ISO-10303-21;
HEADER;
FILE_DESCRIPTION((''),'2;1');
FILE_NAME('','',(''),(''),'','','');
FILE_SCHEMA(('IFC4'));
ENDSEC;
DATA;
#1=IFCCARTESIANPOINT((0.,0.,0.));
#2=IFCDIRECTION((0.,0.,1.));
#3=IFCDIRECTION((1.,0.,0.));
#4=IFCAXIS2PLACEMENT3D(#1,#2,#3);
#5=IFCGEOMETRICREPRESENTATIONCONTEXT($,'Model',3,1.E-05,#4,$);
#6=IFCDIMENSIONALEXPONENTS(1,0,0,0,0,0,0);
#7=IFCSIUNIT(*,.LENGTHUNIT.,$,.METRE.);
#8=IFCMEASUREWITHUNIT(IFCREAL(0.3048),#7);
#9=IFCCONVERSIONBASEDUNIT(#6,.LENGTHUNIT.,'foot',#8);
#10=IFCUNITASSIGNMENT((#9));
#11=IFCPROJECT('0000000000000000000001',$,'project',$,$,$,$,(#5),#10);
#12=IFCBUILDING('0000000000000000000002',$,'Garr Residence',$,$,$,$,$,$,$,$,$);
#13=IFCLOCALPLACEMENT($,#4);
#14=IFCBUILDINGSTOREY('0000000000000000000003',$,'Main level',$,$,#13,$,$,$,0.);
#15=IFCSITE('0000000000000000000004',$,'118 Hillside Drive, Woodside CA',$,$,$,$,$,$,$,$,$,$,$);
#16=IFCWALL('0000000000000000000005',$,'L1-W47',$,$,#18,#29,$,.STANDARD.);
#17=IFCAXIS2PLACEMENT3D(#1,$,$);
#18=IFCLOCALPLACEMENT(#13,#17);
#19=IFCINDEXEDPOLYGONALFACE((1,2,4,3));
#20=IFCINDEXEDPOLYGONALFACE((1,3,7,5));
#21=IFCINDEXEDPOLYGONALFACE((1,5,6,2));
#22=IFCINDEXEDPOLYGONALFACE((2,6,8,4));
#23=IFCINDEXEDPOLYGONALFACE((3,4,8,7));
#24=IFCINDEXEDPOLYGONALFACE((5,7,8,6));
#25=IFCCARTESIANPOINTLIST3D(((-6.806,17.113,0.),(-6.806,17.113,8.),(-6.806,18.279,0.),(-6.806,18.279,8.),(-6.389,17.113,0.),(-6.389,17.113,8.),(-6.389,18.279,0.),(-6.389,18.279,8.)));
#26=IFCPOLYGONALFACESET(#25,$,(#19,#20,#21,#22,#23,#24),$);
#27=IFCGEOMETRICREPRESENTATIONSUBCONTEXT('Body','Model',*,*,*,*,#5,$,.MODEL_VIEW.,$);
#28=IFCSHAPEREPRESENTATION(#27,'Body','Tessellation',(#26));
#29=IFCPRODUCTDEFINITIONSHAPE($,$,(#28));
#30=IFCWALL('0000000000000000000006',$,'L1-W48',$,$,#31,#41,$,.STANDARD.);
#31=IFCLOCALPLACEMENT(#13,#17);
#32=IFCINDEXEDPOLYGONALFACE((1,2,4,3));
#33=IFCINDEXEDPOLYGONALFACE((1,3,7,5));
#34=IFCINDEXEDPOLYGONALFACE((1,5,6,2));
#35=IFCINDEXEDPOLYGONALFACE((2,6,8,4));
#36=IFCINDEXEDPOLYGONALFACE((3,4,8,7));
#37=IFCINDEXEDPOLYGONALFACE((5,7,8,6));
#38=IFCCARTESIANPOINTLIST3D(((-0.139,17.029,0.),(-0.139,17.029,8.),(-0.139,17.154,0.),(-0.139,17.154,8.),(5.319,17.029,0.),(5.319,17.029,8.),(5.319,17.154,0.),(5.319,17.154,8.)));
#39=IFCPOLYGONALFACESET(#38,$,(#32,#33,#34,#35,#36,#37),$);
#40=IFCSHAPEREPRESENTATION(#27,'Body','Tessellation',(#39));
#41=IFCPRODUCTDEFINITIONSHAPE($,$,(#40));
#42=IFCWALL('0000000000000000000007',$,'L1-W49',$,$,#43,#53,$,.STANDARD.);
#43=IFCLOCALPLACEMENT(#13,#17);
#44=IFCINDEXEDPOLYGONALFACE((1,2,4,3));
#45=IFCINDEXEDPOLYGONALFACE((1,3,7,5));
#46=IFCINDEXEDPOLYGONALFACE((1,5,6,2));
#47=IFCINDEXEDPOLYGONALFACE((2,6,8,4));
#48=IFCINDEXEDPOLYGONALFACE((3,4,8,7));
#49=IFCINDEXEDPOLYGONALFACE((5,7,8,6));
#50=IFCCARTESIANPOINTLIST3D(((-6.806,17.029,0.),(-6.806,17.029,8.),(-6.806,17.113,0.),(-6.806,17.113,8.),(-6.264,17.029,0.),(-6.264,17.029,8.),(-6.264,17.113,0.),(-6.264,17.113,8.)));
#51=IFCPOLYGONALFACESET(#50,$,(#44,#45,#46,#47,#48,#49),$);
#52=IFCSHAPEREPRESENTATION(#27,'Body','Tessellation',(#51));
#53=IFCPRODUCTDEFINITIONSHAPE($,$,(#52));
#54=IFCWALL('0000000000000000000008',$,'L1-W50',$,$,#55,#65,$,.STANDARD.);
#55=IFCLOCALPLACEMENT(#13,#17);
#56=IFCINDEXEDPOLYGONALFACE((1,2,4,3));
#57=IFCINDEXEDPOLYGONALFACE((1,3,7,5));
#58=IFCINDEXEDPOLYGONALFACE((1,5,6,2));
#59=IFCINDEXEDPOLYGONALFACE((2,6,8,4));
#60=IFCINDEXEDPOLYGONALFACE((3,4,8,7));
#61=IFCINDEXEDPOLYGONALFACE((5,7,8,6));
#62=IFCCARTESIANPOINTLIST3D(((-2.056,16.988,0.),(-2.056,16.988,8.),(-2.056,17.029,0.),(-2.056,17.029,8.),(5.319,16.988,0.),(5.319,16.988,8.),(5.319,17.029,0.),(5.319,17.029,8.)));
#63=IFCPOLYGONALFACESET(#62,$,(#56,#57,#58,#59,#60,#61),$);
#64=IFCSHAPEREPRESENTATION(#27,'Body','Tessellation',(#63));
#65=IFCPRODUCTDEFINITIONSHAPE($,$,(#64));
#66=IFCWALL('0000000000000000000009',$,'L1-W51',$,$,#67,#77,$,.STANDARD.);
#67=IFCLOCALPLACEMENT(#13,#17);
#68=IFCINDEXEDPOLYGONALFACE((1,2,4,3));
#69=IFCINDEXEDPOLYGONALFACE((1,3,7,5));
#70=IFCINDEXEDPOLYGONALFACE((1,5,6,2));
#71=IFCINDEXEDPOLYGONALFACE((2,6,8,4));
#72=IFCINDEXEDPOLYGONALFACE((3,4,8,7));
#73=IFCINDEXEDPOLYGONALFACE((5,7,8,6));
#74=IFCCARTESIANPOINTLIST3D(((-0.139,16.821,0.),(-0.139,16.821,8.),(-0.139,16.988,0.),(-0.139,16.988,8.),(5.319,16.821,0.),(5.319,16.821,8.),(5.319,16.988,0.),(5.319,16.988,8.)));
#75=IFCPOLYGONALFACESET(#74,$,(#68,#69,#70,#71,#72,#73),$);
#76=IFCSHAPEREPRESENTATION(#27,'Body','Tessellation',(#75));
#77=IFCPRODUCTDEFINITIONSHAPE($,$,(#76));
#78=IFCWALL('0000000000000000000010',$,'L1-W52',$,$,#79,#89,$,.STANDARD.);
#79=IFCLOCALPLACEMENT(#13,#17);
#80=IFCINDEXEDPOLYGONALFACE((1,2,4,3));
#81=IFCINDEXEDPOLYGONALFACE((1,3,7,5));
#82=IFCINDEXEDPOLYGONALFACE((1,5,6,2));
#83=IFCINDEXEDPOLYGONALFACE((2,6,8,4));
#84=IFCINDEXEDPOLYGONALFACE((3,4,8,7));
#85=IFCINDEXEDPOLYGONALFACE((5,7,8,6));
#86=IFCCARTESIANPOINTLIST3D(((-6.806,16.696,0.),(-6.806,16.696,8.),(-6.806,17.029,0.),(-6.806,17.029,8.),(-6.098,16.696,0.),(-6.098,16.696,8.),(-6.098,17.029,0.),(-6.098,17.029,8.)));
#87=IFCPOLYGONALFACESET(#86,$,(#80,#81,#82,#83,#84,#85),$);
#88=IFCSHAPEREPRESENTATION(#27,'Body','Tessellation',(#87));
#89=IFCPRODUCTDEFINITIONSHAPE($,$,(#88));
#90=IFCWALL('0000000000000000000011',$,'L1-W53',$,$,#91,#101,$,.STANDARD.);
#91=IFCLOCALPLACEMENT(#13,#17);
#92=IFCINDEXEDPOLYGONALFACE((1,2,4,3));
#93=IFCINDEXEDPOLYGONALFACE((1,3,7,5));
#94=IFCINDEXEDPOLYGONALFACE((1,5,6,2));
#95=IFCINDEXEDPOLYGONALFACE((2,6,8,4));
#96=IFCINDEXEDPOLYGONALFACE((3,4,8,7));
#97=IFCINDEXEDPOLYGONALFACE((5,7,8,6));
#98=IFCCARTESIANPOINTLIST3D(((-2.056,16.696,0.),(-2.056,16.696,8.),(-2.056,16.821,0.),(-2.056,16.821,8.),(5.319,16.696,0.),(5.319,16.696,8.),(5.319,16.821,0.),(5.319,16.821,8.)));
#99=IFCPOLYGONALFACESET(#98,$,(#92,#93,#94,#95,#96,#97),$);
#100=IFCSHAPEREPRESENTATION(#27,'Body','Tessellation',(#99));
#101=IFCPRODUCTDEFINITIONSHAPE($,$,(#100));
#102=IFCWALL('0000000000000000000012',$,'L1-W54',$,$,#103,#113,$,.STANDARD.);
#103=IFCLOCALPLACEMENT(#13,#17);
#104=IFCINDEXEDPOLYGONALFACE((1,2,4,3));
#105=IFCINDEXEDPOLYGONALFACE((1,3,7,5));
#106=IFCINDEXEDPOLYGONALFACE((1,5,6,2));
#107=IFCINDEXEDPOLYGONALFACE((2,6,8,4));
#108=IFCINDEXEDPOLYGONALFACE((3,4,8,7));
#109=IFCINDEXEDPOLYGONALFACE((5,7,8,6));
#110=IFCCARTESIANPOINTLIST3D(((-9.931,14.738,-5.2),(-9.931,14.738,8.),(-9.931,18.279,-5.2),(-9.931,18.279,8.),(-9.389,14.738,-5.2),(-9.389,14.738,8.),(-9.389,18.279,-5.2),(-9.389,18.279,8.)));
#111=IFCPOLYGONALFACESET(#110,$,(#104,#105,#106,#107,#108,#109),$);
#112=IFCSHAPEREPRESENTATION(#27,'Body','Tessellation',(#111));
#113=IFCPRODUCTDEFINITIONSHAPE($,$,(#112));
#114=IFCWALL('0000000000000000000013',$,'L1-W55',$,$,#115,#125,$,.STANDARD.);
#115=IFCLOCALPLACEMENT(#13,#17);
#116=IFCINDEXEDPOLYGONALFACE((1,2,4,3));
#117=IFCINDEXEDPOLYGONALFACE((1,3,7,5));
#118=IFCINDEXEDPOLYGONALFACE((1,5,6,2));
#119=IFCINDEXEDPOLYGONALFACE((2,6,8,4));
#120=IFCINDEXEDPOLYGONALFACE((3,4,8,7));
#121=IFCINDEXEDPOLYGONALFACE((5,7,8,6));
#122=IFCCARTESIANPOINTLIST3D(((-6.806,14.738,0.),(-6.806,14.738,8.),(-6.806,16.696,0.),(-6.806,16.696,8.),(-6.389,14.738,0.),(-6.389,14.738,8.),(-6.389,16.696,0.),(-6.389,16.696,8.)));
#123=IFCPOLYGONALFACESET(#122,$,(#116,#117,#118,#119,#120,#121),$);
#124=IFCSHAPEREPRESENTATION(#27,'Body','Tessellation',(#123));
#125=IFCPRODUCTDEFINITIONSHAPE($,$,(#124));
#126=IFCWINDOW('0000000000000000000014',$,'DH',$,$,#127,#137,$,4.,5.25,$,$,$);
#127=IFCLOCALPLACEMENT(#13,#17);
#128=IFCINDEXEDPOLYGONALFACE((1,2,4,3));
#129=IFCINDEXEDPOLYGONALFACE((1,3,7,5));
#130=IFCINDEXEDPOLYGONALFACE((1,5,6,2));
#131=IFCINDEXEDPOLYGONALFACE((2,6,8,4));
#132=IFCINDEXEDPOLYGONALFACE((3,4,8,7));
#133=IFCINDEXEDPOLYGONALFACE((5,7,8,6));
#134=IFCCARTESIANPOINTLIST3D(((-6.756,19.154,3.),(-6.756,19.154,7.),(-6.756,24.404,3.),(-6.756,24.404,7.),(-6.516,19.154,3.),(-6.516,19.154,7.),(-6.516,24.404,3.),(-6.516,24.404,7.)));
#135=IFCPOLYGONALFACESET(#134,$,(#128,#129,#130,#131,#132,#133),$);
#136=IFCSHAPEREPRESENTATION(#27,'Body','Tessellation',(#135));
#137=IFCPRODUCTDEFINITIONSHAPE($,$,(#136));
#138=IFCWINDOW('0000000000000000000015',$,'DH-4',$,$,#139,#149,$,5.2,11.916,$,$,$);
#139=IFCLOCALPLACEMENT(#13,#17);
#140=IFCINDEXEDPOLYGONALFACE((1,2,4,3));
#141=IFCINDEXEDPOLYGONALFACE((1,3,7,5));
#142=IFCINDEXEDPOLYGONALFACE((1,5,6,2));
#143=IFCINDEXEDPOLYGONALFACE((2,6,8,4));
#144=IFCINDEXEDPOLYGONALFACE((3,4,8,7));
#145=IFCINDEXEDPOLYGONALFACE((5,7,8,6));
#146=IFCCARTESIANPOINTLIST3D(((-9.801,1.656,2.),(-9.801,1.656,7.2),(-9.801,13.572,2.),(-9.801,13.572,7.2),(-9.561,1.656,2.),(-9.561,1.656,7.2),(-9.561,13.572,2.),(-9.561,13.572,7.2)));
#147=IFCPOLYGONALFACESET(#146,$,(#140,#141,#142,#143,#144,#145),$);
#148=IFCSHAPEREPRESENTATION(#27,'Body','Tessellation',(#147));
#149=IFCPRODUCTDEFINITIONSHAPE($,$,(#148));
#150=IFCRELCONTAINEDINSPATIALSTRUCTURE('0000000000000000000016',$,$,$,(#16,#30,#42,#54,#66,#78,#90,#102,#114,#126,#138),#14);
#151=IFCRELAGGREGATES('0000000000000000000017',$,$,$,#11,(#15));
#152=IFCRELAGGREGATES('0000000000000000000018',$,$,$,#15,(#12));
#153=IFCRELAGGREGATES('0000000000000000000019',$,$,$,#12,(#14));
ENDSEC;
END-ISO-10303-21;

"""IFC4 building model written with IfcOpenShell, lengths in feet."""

from ifc_helpers import new_model, entity, si_unit, converted_unit, frame, origin, origin_with_axes, place, context, subcontext, project, spatial, polyline, outline, extrude, element, save


model = new_model("IFC4")

# Units and contexts
model_context = context("Model", 3, precision=1e-05, world=origin_with_axes())
body_context = subcontext(model_context, "Body", "Model", "MODEL_VIEW")
ifc_project = project(units=[converted_unit("LENGTHUNIT", "foot", entity("IfcReal", 0.3048), si_unit("LENGTHUNIT", "METRE"), dimensions=[1, 0, 0, 0, 0, 0, 0])], contexts=[model_context])

# Site, building, storey
site = spatial("IfcSite", under=ifc_project, Name="118 Hillside Drive, Woodside CA")
building = spatial("IfcBuilding", under=site, Name="Garr Residence")
storey_placement = place(None, origin_with_axes())
storey = spatial("IfcBuildingStorey", under=building, at=storey_placement, Name="Main level", Elevation=0.0)

# Walls
wall_1_placement = place(storey_placement, origin_with_axes())
element("IfcWall", 1, at=wall_1_placement, inside=storey, Name="L1-W47", PredefinedType="STANDARD", context=body_context, shape_type="SweptSolid", body=[
    extrude(outline(polyline([(-6.389, 17.113), (-6.389, 18.279), (-6.806, 18.279), (-6.806, 17.113), (-6.389, 17.113)])), origin(), (0.0, 0.0, 1.0), 8.0),
])
wall_2_placement = place(storey_placement, origin_with_axes())
element("IfcWall", 2, at=wall_2_placement, inside=storey, Name="L1-W48", PredefinedType="STANDARD", context=body_context, shape_type="SweptSolid", body=[
    extrude(outline(polyline([(5.319, 17.029), (5.319, 17.154), (-0.139, 17.154), (-0.139, 17.029), (5.319, 17.029)])), origin(), (0.0, 0.0, 1.0), 8.0),
])
wall_3_placement = place(storey_placement, origin_with_axes())
element("IfcWall", 3, at=wall_3_placement, inside=storey, Name="L1-W49", PredefinedType="STANDARD", context=body_context, shape_type="SweptSolid", body=[
    extrude(outline(polyline([(-6.264, 17.029), (-6.264, 17.113), (-6.806, 17.113), (-6.806, 17.029), (-6.264, 17.029)])), origin(), (0.0, 0.0, 1.0), 8.0),
])
wall_4_placement = place(storey_placement, origin_with_axes())
element("IfcWall", 4, at=wall_4_placement, inside=storey, Name="L1-W50", PredefinedType="STANDARD", context=body_context, shape_type="SweptSolid", body=[
    extrude(outline(polyline([(5.319, 16.988), (5.319, 17.029), (-2.056, 17.029), (-2.056, 16.988), (5.319, 16.988)])), origin(), (0.0, 0.0, 1.0), 8.0),
])
wall_5_placement = place(storey_placement, origin_with_axes())
element("IfcWall", 5, at=wall_5_placement, inside=storey, Name="L1-W51", PredefinedType="STANDARD", context=body_context, shape_type="SweptSolid", body=[
    extrude(outline(polyline([(5.319, 16.821), (5.319, 16.988), (-0.139, 16.988), (-0.139, 16.821), (5.319, 16.821)])), origin(), (0.0, 0.0, 1.0), 8.0),
])
wall_6_placement = place(storey_placement, origin_with_axes())
element("IfcWall", 6, at=wall_6_placement, inside=storey, Name="L1-W52", PredefinedType="STANDARD", context=body_context, shape_type="SweptSolid", body=[
    extrude(outline(polyline([(-6.098, 16.696), (-6.098, 17.029), (-6.806, 17.029), (-6.806, 16.696), (-6.098, 16.696)])), origin(), (0.0, 0.0, 1.0), 8.0),
])
wall_7_placement = place(storey_placement, origin_with_axes())
element("IfcWall", 7, at=wall_7_placement, inside=storey, Name="L1-W53", PredefinedType="STANDARD", context=body_context, shape_type="SweptSolid", body=[
    extrude(outline(polyline([(5.319, 16.696), (5.319, 16.821), (-2.056, 16.821), (-2.056, 16.696), (5.319, 16.696)])), origin(), (0.0, 0.0, 1.0), 8.0),
])
wall_8_placement = place(storey_placement, frame((0.0, 0.0, -5.2), z_axis=(0.0, 0.0, 1.0), x_axis=(1.0, 0.0, 0.0)))
element("IfcWall", 8, at=wall_8_placement, inside=storey, Name="L1-W54", PredefinedType="STANDARD", context=body_context, shape_type="SweptSolid", body=[
    extrude(outline(polyline([(-9.389, 14.738), (-9.389, 18.279), (-9.931, 18.279), (-9.931, 14.738), (-9.389, 14.738)])), origin(), (0.0, 0.0, 1.0), 13.2),
])
wall_9_placement = place(storey_placement, origin_with_axes())
element("IfcWall", 9, at=wall_9_placement, inside=storey, Name="L1-W55", PredefinedType="STANDARD", context=body_context, shape_type="SweptSolid", body=[
    extrude(outline(polyline([(-6.389, 14.738), (-6.389, 16.696), (-6.806, 16.696), (-6.806, 14.738), (-6.389, 14.738)])), origin(), (0.0, 0.0, 1.0), 8.0),
])

# Windows
window_1_placement = place(storey_placement, frame((-6.636, 21.779, 3.0), z_axis=(0.0, 0.0, 1.0), x_axis=(0.0, 1.0, 0.0)))
element("IfcWindow", 10, at=window_1_placement, inside=storey, Name="DH", OverallHeight=4.0, OverallWidth=5.25, context=body_context, shape_type="SweptSolid", body=[
    extrude(outline(polyline([(-2.625, -0.12), (2.625, -0.12), (2.625, 0.12), (-2.625, 0.12), (-2.625, -0.12)])), origin(), (0.0, 0.0, 1.0), 4.0),
])
window_2_placement = place(storey_placement, frame((-9.681, 7.614, 2.0), z_axis=(0.0, 0.0, 1.0), x_axis=(0.0, 1.0, 0.0)))
element("IfcWindow", 11, at=window_2_placement, inside=storey, Name="DH-4", OverallHeight=5.2, OverallWidth=11.916, context=body_context, shape_type="SweptSolid", body=[
    extrude(outline(polyline([(-5.958, -0.12), (5.958, -0.12), (5.958, 0.12), (-5.958, 0.12), (-5.958, -0.12)])), origin(), (0.0, 0.0, 1.0), 5.2),
])

save(model, "model.ifc")
